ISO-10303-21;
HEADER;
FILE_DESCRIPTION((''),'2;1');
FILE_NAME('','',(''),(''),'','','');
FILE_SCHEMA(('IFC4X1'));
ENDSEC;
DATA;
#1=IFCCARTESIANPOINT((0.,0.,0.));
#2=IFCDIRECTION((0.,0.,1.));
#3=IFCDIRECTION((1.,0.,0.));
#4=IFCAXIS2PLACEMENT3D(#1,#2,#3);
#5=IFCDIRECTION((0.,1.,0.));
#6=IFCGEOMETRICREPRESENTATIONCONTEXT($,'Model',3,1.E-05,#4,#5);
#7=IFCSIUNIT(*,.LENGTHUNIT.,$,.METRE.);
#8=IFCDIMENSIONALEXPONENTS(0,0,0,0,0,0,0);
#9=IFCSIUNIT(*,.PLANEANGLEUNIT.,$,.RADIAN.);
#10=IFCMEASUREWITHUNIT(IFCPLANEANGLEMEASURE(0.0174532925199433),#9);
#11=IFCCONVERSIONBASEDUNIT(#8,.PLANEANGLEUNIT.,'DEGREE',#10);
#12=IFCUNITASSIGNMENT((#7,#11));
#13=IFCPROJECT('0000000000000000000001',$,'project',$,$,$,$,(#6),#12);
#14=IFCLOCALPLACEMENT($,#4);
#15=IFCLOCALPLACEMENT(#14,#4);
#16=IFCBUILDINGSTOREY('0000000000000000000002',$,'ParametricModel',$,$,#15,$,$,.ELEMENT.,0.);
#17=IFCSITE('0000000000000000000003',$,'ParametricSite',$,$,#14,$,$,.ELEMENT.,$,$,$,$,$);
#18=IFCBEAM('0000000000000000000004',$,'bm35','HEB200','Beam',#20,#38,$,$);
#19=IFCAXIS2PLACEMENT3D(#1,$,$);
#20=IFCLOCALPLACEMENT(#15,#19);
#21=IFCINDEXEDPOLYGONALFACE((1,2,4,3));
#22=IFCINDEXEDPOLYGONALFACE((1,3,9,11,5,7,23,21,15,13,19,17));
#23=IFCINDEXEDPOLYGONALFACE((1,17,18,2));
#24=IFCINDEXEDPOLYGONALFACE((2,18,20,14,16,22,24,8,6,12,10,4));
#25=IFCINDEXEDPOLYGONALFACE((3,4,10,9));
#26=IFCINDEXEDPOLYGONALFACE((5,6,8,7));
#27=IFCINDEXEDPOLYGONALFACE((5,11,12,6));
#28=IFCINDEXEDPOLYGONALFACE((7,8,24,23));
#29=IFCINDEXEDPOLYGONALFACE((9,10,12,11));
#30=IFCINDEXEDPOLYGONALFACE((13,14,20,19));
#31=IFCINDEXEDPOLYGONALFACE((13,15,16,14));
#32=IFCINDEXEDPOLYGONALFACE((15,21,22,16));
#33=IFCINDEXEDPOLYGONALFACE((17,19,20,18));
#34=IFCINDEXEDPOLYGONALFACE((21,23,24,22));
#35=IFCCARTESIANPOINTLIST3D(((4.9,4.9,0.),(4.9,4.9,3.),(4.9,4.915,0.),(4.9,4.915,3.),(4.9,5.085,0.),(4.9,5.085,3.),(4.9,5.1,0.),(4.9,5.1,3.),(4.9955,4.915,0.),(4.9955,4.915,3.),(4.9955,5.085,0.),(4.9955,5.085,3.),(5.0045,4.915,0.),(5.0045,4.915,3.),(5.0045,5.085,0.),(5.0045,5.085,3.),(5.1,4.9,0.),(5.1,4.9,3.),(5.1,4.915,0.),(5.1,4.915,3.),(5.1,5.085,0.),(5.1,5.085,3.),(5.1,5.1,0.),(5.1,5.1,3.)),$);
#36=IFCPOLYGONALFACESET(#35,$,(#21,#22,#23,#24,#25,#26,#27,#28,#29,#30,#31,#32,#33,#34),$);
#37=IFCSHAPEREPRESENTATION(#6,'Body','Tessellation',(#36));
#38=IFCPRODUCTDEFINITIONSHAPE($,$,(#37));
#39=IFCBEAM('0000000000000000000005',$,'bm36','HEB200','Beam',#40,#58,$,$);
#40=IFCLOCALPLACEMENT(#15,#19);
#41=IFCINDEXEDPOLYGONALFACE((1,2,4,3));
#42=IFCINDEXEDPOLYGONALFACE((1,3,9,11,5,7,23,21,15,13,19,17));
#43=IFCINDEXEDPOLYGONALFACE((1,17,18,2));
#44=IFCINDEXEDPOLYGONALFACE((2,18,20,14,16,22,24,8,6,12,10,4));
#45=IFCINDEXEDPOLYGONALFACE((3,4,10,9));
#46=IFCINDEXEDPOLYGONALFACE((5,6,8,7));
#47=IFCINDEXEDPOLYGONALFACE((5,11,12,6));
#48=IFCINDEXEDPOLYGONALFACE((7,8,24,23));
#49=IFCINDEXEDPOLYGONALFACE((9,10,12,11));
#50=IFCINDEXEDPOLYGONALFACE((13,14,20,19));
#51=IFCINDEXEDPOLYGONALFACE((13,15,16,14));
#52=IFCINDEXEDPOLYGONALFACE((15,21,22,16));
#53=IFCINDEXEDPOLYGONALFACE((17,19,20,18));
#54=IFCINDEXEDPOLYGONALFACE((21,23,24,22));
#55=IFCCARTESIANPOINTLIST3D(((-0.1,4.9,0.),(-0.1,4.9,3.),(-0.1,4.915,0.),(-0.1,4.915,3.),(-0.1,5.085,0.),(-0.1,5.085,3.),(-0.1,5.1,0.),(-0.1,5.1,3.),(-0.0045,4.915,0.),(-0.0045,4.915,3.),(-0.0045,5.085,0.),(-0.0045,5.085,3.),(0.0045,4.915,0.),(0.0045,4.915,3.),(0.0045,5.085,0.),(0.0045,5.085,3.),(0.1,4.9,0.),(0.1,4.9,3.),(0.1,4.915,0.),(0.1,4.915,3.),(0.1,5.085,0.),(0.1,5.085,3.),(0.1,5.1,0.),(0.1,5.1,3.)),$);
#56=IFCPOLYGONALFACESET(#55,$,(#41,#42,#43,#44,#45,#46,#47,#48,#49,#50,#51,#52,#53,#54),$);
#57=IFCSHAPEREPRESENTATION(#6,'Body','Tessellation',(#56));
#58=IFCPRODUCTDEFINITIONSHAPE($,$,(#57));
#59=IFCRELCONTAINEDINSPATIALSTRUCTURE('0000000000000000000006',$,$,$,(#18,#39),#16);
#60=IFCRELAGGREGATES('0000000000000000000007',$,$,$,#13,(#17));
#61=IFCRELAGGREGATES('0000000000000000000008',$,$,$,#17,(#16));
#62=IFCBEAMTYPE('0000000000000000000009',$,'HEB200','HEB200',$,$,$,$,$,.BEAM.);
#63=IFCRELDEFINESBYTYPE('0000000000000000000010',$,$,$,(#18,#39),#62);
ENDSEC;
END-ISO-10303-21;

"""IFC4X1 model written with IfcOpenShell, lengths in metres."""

from ifc_helpers import new_model, entity, si_unit, converted_unit, direction, frame, origin, origin_with_axes, place, context, project, spatial, i_section, extrude, type_object, element, save


model = new_model("IFC4X1")

# Units and contexts
model_context = context("Model", 3, precision=1e-05, world=origin_with_axes(), true_north=direction((0.0, 1.0, 0.0)))
ifc_project = project(units=[si_unit("LENGTHUNIT", "METRE"), converted_unit("PLANEANGLEUNIT", "DEGREE", entity("IfcPlaneAngleMeasure", 0.0174532925199433), si_unit("PLANEANGLEUNIT", "RADIAN"), dimensions=[0, 0, 0, 0, 0, 0, 0])], contexts=[model_context])

# Site, storey
site_placement = place(None, origin_with_axes())
site = spatial("IfcSite", under=ifc_project, at=site_placement, Name="ParametricSite", CompositionType="ELEMENT")
storey_placement = place(site_placement, origin_with_axes())
storey = spatial("IfcBuildingStorey", under=site, at=storey_placement, Name="ParametricModel", CompositionType="ELEMENT", Elevation=0.0)

# Beams
placement = place(storey_placement, origin_with_axes())
beam_type_1 = type_object("IfcBeamType", Name="HEB200", Description="HEB200", PredefinedType="BEAM")
for number, where, z_axis, x_axis, name in (
    (1, (5.0, 5.0, 0.0), (0.0, 0.0, 1.0), (1.0, 0.0, 0.0), "bm35"),
    (2, (0.0, 5.0, 0.0), (0.0, 0.0, 1.0), (1.0, 0.0, 0.0), "bm36"),
):
    element("IfcBeam", number, at=place(placement, frame(where, z_axis=z_axis, x_axis=x_axis)), inside=storey, type_object=beam_type_1, Name=name, Description="HEB200", ObjectType="Beam", context=model_context, shape_type="SweptSolid", body=[
        extrude(i_section(OverallWidth=0.2, OverallDepth=0.2, WebThickness=0.009, FlangeThickness=0.015), origin(), (0.0, 0.0, 1.0), 3.0),
    ])

save(model, "model.ifc")
